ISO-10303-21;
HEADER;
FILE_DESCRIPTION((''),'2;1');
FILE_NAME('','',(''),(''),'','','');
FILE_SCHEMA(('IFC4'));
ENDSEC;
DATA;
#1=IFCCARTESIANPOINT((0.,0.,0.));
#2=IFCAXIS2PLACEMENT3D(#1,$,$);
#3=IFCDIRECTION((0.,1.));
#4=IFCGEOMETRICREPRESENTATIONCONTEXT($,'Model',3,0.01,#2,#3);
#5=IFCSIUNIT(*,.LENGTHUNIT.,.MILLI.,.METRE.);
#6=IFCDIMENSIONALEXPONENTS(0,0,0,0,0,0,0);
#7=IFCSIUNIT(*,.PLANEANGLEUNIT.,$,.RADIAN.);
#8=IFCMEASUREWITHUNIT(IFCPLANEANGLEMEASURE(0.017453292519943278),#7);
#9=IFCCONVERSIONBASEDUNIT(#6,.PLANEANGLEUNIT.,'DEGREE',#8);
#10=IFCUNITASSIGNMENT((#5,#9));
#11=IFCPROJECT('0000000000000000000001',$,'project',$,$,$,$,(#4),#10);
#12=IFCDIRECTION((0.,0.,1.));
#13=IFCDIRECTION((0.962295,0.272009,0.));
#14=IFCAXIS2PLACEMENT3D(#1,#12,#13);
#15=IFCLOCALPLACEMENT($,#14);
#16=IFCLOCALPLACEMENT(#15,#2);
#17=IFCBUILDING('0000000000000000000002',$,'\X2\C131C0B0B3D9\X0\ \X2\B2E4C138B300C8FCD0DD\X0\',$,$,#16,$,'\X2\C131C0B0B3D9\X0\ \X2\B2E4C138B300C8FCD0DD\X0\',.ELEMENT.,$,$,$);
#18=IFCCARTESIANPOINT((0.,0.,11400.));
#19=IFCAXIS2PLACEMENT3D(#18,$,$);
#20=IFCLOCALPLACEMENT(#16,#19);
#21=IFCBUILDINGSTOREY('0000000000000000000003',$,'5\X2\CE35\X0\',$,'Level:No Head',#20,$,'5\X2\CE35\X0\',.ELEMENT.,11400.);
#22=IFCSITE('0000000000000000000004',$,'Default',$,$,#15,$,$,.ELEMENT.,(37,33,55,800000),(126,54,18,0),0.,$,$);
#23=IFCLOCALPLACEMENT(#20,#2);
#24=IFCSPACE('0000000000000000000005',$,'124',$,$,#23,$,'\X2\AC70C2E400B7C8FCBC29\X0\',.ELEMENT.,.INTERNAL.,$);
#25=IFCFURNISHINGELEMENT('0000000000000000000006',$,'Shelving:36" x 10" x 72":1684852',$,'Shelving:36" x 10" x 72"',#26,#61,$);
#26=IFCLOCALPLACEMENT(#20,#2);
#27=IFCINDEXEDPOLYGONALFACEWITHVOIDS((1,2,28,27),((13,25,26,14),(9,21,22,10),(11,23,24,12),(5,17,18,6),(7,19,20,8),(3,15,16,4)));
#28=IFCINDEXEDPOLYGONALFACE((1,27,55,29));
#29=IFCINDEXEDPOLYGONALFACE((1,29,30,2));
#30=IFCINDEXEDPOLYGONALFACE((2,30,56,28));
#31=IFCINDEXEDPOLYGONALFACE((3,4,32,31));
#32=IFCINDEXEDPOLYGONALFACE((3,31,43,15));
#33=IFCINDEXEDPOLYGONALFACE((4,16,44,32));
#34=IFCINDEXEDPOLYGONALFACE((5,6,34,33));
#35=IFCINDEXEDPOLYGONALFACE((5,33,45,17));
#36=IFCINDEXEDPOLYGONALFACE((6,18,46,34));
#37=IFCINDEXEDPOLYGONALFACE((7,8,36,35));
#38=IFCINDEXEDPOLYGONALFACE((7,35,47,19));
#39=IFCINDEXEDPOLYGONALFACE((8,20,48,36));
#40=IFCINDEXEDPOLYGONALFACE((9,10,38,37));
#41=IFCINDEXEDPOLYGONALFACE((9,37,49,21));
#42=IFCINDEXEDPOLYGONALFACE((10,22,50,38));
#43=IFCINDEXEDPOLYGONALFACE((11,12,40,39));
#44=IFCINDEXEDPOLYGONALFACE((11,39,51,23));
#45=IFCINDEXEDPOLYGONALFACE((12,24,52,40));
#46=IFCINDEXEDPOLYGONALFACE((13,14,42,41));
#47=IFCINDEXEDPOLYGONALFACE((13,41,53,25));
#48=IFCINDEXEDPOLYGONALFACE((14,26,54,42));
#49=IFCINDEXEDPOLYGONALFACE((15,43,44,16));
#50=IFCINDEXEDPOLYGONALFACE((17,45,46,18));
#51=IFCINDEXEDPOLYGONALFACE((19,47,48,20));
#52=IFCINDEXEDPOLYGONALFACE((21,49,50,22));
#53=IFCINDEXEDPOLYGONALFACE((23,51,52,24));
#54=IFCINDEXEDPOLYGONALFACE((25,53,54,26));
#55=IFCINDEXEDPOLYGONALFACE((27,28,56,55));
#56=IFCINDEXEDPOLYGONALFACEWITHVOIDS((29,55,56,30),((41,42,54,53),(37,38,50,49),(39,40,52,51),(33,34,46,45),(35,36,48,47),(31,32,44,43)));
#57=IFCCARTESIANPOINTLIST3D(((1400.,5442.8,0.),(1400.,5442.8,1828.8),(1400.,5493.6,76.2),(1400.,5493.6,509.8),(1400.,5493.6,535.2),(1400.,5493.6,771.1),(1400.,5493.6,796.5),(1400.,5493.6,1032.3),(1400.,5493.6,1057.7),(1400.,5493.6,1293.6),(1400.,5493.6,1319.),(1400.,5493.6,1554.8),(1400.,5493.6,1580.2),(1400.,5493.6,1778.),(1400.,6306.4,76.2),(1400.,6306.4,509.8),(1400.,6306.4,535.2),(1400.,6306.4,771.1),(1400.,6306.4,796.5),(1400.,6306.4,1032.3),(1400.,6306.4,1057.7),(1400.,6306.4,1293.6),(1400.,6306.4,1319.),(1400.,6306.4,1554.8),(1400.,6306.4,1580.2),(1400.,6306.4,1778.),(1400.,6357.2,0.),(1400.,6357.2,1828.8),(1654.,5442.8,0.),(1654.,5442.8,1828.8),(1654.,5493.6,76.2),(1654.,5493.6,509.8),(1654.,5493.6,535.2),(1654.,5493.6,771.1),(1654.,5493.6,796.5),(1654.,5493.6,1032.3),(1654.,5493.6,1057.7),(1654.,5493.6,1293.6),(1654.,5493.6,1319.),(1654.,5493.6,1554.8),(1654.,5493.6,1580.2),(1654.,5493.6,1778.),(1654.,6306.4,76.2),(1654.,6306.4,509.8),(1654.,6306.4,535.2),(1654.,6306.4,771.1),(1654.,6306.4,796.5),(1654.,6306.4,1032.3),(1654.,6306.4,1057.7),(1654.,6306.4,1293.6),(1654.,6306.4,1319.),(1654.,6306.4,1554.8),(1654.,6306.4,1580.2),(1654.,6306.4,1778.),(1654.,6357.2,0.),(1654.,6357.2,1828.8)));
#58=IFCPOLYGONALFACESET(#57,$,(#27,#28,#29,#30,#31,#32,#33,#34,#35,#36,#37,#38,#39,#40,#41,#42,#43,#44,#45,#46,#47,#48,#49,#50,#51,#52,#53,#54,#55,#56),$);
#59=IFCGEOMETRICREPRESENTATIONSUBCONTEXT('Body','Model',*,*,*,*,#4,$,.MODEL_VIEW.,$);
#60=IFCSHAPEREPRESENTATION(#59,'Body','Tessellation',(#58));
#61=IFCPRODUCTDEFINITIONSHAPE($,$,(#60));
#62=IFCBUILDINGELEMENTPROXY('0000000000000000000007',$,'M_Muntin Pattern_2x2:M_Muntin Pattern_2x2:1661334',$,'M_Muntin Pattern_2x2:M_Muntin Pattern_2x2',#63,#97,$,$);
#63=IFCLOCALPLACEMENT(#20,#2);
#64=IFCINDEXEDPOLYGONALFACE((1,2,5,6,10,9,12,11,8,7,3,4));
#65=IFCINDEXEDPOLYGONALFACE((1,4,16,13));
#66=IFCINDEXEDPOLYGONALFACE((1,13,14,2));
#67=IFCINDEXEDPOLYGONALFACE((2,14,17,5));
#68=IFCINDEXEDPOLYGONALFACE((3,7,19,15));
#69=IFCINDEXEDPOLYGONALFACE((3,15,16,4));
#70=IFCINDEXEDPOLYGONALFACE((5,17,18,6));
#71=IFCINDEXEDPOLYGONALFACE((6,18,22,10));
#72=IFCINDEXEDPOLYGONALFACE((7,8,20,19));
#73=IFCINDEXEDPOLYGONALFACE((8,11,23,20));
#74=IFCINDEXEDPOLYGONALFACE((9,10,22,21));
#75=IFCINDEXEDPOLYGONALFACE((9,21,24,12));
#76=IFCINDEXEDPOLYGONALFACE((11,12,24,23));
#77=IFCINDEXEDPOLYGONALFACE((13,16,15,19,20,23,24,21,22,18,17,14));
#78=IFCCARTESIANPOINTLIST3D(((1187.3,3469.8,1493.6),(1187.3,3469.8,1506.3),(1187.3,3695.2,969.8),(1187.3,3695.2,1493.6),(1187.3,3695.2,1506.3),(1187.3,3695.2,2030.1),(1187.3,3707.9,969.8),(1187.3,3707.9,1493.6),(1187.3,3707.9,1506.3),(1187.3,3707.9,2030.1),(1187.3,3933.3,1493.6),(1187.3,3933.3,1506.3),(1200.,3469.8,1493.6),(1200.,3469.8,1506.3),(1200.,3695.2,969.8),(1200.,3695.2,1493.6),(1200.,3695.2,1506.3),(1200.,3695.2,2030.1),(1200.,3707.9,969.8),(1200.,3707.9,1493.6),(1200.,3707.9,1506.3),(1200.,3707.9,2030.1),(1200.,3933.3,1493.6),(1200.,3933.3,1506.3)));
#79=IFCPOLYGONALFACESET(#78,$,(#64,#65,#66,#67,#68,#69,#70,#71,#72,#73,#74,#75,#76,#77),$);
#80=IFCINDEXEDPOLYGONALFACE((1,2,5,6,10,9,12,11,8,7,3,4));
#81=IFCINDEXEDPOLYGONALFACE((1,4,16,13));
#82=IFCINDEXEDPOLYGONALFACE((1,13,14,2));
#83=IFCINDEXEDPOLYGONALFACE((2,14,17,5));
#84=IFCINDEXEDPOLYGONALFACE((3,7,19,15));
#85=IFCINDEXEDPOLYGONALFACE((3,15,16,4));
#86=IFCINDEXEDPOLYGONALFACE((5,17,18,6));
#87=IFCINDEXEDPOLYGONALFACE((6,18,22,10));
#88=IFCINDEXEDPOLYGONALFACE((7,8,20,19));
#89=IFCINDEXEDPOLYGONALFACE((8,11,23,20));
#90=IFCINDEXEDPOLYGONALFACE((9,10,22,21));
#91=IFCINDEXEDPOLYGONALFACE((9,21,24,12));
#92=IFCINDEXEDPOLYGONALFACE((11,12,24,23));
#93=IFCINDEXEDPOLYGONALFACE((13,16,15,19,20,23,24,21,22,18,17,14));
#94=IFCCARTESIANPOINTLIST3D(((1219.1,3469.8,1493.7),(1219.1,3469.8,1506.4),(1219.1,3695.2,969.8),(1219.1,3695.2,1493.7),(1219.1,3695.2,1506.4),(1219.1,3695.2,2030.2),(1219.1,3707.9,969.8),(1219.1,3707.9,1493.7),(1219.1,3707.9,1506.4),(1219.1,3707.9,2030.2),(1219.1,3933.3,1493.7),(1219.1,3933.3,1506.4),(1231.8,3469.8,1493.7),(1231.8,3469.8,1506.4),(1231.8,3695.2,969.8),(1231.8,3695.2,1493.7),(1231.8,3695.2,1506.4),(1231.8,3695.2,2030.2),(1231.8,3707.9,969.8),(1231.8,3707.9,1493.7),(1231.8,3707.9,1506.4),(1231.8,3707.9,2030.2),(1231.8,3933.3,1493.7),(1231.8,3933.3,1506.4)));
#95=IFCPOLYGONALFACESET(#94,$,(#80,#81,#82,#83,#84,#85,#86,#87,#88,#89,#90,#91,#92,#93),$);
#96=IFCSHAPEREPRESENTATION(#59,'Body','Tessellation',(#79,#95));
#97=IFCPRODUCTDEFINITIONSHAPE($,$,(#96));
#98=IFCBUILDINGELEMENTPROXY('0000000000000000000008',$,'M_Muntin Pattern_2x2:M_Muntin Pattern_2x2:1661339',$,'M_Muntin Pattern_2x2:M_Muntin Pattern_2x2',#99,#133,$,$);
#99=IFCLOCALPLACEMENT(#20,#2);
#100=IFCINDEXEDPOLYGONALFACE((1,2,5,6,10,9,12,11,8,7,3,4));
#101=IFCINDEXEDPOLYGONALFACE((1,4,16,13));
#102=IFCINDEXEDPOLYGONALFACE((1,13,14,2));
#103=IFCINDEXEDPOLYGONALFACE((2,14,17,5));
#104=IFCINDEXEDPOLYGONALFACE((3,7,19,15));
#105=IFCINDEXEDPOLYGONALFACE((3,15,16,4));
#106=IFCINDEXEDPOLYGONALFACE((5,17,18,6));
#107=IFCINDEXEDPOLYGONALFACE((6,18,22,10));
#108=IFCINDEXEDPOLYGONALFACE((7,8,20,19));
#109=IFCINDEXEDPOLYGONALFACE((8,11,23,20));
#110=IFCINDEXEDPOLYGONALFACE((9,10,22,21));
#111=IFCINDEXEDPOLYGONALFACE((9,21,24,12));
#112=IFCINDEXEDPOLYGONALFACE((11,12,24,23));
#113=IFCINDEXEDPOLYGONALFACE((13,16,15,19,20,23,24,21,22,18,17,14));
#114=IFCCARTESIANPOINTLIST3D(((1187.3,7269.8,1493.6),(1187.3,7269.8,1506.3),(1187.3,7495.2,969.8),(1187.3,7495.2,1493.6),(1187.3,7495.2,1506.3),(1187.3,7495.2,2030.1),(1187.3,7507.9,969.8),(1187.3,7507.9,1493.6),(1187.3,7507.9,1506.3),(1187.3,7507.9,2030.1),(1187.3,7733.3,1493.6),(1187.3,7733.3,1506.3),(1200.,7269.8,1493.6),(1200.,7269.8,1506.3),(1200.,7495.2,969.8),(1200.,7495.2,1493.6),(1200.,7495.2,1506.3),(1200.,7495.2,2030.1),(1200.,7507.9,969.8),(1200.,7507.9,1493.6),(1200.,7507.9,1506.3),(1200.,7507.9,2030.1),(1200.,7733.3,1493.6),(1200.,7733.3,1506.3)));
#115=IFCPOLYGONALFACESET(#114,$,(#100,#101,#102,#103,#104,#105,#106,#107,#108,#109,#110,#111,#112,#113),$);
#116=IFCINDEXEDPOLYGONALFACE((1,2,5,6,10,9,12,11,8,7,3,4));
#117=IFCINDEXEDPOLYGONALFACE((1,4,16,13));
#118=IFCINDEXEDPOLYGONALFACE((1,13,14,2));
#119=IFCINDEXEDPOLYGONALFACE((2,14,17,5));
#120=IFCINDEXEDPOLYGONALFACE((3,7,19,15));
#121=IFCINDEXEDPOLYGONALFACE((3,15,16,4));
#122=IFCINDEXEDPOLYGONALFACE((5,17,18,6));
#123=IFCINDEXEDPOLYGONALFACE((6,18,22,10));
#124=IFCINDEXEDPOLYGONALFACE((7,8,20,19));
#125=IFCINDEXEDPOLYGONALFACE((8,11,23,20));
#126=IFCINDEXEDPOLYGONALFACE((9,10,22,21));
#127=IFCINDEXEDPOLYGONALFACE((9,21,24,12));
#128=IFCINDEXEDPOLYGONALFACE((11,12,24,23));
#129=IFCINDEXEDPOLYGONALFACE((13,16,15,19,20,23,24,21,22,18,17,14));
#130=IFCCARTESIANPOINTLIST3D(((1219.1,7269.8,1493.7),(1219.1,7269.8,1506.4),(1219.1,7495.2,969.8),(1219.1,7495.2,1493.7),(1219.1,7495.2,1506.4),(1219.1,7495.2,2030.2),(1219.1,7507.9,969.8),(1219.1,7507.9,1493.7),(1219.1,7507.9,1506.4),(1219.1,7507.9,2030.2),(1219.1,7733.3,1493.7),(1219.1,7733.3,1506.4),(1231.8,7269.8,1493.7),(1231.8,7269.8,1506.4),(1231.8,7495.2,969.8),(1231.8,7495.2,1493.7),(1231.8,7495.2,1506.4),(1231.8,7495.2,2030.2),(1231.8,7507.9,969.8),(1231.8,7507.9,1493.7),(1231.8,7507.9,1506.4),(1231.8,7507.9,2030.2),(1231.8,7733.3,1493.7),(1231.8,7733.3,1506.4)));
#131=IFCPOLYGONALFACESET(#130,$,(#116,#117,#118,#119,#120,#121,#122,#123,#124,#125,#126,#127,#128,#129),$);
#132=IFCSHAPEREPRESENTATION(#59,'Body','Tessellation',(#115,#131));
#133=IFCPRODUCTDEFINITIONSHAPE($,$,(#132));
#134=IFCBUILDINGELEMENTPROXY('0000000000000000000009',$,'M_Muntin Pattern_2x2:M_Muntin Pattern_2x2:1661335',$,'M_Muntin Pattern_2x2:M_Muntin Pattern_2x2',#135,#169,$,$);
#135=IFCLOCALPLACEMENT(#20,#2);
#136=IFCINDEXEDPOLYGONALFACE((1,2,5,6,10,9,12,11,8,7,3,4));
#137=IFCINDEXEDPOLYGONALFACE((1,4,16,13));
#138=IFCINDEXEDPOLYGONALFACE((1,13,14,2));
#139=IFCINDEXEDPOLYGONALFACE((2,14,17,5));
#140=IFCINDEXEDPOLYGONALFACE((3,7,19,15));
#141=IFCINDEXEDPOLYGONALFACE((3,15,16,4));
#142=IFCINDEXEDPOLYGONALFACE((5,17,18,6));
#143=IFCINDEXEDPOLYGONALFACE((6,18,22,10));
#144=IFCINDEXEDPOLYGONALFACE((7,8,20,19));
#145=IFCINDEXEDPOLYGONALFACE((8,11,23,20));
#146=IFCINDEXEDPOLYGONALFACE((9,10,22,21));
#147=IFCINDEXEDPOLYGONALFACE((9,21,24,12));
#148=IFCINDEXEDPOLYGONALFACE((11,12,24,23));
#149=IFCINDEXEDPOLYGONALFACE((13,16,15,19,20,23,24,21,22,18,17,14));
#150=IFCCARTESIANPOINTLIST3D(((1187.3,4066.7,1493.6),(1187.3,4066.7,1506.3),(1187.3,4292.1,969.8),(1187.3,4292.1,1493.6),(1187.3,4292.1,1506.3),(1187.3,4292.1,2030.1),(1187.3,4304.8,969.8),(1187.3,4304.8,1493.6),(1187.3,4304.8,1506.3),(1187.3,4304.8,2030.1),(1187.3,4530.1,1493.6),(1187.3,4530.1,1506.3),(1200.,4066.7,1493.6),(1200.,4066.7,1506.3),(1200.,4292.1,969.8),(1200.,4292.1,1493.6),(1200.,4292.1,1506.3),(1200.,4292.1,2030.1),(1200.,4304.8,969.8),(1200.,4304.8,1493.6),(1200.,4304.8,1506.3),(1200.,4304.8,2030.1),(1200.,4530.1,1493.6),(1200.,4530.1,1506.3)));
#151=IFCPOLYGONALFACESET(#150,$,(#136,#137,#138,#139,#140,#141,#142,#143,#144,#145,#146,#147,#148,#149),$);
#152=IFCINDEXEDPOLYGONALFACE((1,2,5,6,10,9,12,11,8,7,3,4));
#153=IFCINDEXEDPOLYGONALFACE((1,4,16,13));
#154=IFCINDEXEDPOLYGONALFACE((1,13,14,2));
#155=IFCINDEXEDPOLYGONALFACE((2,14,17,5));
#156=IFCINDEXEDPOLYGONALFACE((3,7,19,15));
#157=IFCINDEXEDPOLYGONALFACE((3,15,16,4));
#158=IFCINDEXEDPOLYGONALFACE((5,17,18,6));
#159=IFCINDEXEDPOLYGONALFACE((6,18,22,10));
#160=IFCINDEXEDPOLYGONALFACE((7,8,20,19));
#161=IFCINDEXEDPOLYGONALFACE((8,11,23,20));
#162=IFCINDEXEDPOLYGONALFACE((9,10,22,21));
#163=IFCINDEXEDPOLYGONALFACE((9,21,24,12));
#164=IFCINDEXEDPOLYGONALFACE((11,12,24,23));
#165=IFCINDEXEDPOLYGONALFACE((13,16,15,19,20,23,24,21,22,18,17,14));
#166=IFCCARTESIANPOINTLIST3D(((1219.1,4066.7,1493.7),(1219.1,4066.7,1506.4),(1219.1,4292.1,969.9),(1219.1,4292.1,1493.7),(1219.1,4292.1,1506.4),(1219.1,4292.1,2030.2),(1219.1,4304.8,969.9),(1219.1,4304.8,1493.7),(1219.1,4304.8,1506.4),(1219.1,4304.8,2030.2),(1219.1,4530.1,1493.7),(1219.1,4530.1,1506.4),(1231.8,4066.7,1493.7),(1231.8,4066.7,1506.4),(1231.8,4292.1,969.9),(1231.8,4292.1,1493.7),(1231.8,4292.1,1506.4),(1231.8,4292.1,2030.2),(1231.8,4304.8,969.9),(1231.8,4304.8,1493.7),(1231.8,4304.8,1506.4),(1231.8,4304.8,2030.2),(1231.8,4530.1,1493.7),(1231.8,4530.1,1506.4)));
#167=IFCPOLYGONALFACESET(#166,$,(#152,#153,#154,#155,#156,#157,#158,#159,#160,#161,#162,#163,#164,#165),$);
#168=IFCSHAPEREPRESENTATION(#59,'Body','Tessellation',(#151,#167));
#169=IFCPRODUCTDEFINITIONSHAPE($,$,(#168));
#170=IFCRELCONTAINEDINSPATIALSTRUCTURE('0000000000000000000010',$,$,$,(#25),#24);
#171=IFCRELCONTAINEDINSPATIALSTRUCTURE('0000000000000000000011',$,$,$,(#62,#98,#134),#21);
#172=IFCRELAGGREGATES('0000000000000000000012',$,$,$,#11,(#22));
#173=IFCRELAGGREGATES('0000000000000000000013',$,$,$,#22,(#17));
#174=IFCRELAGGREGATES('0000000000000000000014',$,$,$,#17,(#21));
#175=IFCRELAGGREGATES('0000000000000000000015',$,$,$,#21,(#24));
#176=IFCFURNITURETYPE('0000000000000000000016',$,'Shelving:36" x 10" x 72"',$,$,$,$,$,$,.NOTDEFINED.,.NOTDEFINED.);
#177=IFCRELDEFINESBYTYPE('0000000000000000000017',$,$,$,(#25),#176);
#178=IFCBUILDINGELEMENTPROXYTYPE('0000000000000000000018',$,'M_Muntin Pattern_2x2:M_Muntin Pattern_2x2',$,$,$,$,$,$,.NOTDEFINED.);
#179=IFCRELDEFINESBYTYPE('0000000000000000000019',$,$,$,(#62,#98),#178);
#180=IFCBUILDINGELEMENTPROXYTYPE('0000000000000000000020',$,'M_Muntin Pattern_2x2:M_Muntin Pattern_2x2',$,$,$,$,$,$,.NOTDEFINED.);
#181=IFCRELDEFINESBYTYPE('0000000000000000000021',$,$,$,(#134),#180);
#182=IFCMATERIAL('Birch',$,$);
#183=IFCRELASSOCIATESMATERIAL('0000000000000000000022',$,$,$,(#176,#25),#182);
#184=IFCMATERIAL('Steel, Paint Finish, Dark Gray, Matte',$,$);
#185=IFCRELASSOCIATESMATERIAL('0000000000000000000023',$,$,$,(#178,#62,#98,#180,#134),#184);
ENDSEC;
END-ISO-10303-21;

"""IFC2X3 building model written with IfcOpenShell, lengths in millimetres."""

from ifc_helpers import new_model, entity, si_unit, converted_unit, direction, frame, origin, place, context, subcontext, project, spatial, polyline, outline, extrude, source, transform, mapped, material, type_object, type_shapes, element, save


model = new_model("IFC2X3")

# Units and contexts
model_context = context("Model", 3, precision=0.01, world=origin(), true_north=direction((0.0, 1.0)))
body_context = subcontext(model_context, "Body", "Model", "MODEL_VIEW")
ifc_project = project(units=[si_unit("LENGTHUNIT", "METRE", prefix="MILLI"), converted_unit("PLANEANGLEUNIT", "DEGREE", entity("IfcPlaneAngleMeasure", 0.017453292519943278), si_unit("PLANEANGLEUNIT", "RADIAN"), dimensions=[0, 0, 0, 0, 0, 0, 0])], contexts=[model_context])

# Site, building, storey
site_placement = place(None, frame((0.0, 0.0, 0.0), z_axis=(0.0, 0.0, 1.0), x_axis=(0.962295, 0.272009, 0.0)))
site = spatial("IfcSite", under=ifc_project, at=site_placement, Name="Default", CompositionType="ELEMENT", RefLatitude=(37, 33, 55, 800000), RefLongitude=(126, 54, 18, 0), RefElevation=0.0)
building_placement = place(site_placement, origin())
building = spatial("IfcBuilding", under=site, at=building_placement, Name="성산동 다세대주택", LongName="성산동 다세대주택", CompositionType="ELEMENT")
storey_placement = place(building_placement, frame((0.0, 0.0, 11400.0)))
storey = spatial("IfcBuildingStorey", under=building, at=storey_placement, Name="5층", ObjectType="Level:No Head", LongName="5층", CompositionType="ELEMENT", Elevation=11400.0)

# Shared definitions
space_1_placement = place(storey_placement, origin())
space_1 = spatial("IfcSpace", under=storey, at=space_1_placement, Name="124", LongName="거실·주방", CompositionType="ELEMENT", InteriorOrExteriorSpace="INTERNAL")

# Furnishing element
ifc_material_1 = material(Name="Birch")
furniture_type_1 = type_object("IfcFurnitureType", Name="Shelving:36\" x 10\" x 72\"", AssemblyPlace="NOTDEFINED", material=ifc_material_1)
shared_shape_1 = source(origin(), body_context, "Body", "SweptSolid", [
    extrude(outline(polyline([(-457.2, -914.4), (457.2, -914.4), (457.2, 914.4), (-457.2, 914.4), (-457.2, -914.4)]), holes=[polyline([(-406.4, 863.6), (406.4, 863.6), (406.4, 665.8), (-406.4, 665.8), (-406.4, 863.6)]), polyline([(-406.4, -838.2), (-406.4, -404.6), (406.4, -404.6), (406.4, -838.2), (-406.4, -838.2)]), polyline([(406.4, 143.3), (-406.4, 143.3), (-406.4, 379.2), (406.4, 379.2), (406.4, 143.3)]), polyline([(-406.4, 640.4), (406.4, 640.4), (406.4, 404.6), (-406.4, 404.6), (-406.4, 640.4)]), polyline([(-406.4, 117.9), (406.4, 117.9), (406.4, -117.9), (-406.4, -117.9), (-406.4, 117.9)]), polyline([(-406.4, -143.3), (406.4, -143.3), (406.4, -379.2), (-406.4, -379.2), (-406.4, -143.3)])]), frame((0.0, -431.8, 914.4), z_axis=(0.0, 1.0, 0.0), x_axis=(-1.0, 0.0, 0.0)), (0.0, 0.0, 1.0), 254.0),
])
type_shapes(furniture_type_1, [shared_shape_1])
furnishing_1_placement = place(space_1_placement, frame((1222.2, 5900.0, 0.0), z_axis=(0.0, 0.0, 1.0), x_axis=(0.0, 1.0, 0.0)))
element("IfcFurnishingElement", 1, at=furnishing_1_placement, inside=space_1, type_object=furniture_type_1, material=ifc_material_1, Name="Shelving:36\" x 10\" x 72\":1684852", ObjectType="Shelving:36\" x 10\" x 72\"", context=body_context, shape_type="MappedRepresentation", body=[
    mapped(shared_shape_1, transform((0.0, 0.0, 0.0), scale=1.0)),
])

# Building element proxies
ifc_material_2 = material(Name="Steel, Paint Finish, Dark Gray, Matte")
building_element_proxy_type_1 = type_object("IfcBuildingElementProxyType", Name="M_Muntin Pattern_2x2:M_Muntin Pattern_2x2", PredefinedType="NOTDEFINED", material=ifc_material_2)
shared_shape_2 = source(origin(), body_context, "Body", "SweptSolid", [
    extrude(outline(polyline([(6.4, -6.4), (530.1, -6.4), (530.1, 6.3), (6.4, 6.3), (6.4, 231.7), (-6.3, 231.7), (-6.3, 6.3), (-530.2, 6.3), (-530.2, -6.4), (-6.3, -6.4), (-6.3, -231.7), (6.4, -231.7), (6.4, -6.4)])), frame((0.0, 9.5, 530.1), z_axis=(0.0, 1.0, 0.0), x_axis=(0.0, 0.0, 1.0)), (0.0, 0.0, 1.0), 12.7),
    extrude(outline(polyline([(6.4, -6.4), (530.2, -6.4), (530.2, 6.3), (6.4, 6.3), (6.4, 231.7), (-6.3, 231.7), (-6.3, 6.3), (-530.2, 6.3), (-530.2, -6.4), (-6.3, -6.4), (-6.3, -231.7), (6.4, -231.7), (6.4, -6.4)])), frame((0.0, -22.2, 530.2), z_axis=(0.0, 1.0, 0.0), x_axis=(0.0, 0.0, 1.0)), (0.0, 0.0, 1.0), 12.7),
])
type_shapes(building_element_proxy_type_1, [shared_shape_2])
for number, where, z_axis, x_axis, name in (
    (2, (1209.5, 3701.6, 969.8), (0.0, 0.0, 1.0), (0.0, 1.0, 0.0), "M_Muntin Pattern_2x2:M_Muntin Pattern_2x2:1661334"),
    (3, (1209.5, 7501.6, 969.8), (0.0, 0.0, 1.0), (0.0, 1.0, 0.0), "M_Muntin Pattern_2x2:M_Muntin Pattern_2x2:1661339"),
):
    element("IfcBuildingElementProxy", number, at=place(storey_placement, frame(where, z_axis=z_axis, x_axis=x_axis)), inside=storey, type_object=building_element_proxy_type_1, material=ifc_material_2, Name=name, ObjectType="M_Muntin Pattern_2x2:M_Muntin Pattern_2x2", context=body_context, shape_type="MappedRepresentation", body=[
        mapped(shared_shape_2, transform((0.0, 0.0, 0.0), scale=1.0)),
    ])
building_element_proxy_type_2 = type_object("IfcBuildingElementProxyType", Name="M_Muntin Pattern_2x2:M_Muntin Pattern_2x2", PredefinedType="NOTDEFINED", material=ifc_material_2)
shared_shape_3 = source(origin(), body_context, "Body", "SweptSolid", [
    extrude(outline(polyline([(6.4, -6.4), (530.1, -6.4), (530.1, 6.3), (6.4, 6.3), (6.4, 231.7), (-6.3, 231.7), (-6.3, 6.3), (-530.2, 6.3), (-530.2, -6.4), (-6.3, -6.4), (-6.3, -231.7), (6.4, -231.7), (6.4, -6.4)])), frame((0.0, -22.2, 530.1), z_axis=(0.0, 1.0, 0.0), x_axis=(0.0, 0.0, 1.0)), (0.0, 0.0, 1.0), 12.7),
    extrude(outline(polyline([(6.4, -6.4), (530.2, -6.4), (530.2, 6.3), (6.4, 6.3), (6.4, 231.7), (-6.3, 231.7), (-6.3, 6.3), (-530.2, 6.3), (-530.2, -6.4), (-6.3, -6.4), (-6.3, -231.7), (6.4, -231.7), (6.4, -6.4)])), frame((0.0, 9.5, 530.2), z_axis=(0.0, 1.0, 0.0), x_axis=(0.0, 0.0, 1.0)), (0.0, 0.0, 1.0), 12.7),
])
type_shapes(building_element_proxy_type_2, [shared_shape_3])
for number, where, z_axis, x_axis, name in (
    (4, (1209.5, 4298.4, 969.9), (0.0, 0.0, 1.0), (0.0, -1.0, 0.0), "M_Muntin Pattern_2x2:M_Muntin Pattern_2x2:1661335"),
):
    element("IfcBuildingElementProxy", number, at=place(storey_placement, frame(where, z_axis=z_axis, x_axis=x_axis)), inside=storey, type_object=building_element_proxy_type_2, material=ifc_material_2, Name=name, ObjectType="M_Muntin Pattern_2x2:M_Muntin Pattern_2x2", context=body_context, shape_type="MappedRepresentation", body=[
        mapped(shared_shape_3, transform((0.0, 0.0, 0.0), scale=1.0)),
    ])

save(model, "model.ifc")
